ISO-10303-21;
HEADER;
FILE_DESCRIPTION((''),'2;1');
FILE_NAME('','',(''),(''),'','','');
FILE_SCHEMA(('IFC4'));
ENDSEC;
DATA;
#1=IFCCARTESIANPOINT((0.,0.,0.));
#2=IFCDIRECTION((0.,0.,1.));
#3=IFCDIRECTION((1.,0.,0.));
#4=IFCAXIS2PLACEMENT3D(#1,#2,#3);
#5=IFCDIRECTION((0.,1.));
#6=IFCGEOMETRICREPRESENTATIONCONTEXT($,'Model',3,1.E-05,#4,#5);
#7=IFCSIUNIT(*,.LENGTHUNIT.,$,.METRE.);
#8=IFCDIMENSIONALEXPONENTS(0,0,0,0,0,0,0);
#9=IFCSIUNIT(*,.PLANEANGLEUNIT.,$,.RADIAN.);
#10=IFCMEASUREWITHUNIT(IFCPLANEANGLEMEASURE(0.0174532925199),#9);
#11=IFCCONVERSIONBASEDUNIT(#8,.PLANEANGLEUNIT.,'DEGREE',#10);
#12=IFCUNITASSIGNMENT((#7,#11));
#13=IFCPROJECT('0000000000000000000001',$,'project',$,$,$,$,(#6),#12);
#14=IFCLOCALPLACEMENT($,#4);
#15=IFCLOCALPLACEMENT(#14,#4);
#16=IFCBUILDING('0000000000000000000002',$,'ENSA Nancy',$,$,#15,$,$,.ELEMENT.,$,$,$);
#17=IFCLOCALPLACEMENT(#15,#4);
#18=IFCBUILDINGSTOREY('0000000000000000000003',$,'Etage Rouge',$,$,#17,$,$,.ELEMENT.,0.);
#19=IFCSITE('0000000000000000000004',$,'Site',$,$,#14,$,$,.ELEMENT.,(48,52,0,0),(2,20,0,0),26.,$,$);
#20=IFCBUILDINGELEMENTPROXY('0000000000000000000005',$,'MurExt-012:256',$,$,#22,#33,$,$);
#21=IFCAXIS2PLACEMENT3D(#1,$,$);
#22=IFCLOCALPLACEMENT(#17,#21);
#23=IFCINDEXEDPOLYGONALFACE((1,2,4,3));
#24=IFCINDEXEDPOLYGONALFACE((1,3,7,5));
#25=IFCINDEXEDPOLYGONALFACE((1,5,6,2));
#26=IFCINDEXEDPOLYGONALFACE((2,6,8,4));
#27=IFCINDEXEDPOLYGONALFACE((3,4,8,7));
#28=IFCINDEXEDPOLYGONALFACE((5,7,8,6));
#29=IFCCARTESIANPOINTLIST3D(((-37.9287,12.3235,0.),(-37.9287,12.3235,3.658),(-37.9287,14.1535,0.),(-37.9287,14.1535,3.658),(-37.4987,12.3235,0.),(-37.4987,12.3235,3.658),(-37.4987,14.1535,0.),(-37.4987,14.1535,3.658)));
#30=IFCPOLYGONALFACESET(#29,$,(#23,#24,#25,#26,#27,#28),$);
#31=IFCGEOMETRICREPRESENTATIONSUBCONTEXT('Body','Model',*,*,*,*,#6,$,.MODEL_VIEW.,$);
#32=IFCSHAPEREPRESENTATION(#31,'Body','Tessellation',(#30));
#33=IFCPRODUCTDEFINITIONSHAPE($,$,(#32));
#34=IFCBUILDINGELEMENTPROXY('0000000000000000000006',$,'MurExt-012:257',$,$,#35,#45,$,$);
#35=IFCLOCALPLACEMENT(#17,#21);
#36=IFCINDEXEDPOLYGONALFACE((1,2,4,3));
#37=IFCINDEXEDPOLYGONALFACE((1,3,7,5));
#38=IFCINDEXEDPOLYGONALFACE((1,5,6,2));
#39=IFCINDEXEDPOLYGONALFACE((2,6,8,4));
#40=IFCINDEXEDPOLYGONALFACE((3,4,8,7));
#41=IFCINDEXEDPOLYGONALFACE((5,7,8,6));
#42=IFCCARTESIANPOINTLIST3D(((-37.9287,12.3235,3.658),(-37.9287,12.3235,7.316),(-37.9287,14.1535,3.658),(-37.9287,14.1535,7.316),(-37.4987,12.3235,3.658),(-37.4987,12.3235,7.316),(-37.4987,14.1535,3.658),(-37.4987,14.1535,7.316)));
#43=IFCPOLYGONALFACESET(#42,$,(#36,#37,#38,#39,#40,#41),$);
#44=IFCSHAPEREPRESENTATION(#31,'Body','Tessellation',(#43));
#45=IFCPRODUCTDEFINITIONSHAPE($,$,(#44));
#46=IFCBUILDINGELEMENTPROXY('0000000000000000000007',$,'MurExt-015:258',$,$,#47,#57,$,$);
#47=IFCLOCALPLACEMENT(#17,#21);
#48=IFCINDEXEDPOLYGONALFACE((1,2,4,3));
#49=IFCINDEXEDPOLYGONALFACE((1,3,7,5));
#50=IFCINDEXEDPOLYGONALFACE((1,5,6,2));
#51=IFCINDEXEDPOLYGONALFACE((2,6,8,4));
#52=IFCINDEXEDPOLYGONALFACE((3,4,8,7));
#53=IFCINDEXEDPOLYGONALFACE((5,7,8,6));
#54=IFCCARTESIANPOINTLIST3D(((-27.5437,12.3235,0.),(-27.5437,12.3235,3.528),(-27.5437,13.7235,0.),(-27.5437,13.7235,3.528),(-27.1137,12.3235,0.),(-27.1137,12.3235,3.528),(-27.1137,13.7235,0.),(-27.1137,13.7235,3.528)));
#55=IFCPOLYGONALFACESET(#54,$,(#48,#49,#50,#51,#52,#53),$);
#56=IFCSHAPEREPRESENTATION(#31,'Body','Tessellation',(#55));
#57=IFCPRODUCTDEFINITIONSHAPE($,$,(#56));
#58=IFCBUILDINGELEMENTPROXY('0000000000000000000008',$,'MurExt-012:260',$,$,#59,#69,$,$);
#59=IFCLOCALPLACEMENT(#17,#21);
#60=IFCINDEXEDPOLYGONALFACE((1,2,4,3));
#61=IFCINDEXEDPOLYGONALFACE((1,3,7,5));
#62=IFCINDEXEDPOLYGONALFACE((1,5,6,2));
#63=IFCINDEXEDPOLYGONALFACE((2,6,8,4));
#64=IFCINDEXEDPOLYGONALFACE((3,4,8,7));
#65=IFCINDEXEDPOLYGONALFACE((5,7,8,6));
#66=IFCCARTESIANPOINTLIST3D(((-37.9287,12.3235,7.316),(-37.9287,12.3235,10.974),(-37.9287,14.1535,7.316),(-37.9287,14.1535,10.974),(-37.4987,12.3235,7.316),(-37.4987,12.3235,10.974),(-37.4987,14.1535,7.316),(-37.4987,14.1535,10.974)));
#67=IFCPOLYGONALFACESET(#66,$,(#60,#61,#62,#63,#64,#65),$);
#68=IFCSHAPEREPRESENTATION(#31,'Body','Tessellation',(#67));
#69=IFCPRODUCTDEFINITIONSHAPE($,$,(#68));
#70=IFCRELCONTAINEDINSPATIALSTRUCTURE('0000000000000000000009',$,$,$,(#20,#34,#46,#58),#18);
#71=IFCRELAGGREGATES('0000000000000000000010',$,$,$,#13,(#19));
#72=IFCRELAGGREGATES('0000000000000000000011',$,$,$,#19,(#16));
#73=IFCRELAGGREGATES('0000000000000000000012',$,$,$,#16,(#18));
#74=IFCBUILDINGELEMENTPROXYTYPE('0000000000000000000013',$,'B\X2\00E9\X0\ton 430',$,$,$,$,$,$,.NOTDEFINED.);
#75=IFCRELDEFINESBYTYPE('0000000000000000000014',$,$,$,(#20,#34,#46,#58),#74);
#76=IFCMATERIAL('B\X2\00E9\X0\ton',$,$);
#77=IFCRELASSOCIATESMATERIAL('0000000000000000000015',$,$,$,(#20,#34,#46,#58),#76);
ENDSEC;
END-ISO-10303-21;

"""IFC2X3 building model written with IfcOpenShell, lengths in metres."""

from ifc_helpers import new_model, entity, si_unit, converted_unit, direction, frame, origin_with_axes, place, context, subcontext, project, spatial, polyline, outline, extrude, material, type_object, element, save


model = new_model("IFC2X3")

# Units and contexts
model_context = context("Model", 3, precision=1e-05, world=origin_with_axes(), true_north=direction((0.0, 1.0)))
body_context = subcontext(model_context, "Body", "Model", "MODEL_VIEW")
ifc_project = project(units=[si_unit("LENGTHUNIT", "METRE"), converted_unit("PLANEANGLEUNIT", "DEGREE", entity("IfcPlaneAngleMeasure", 0.0174532925199), si_unit("PLANEANGLEUNIT", "RADIAN"), dimensions=[0, 0, 0, 0, 0, 0, 0])], contexts=[model_context])

# Site, building, storey
site_placement = place(None, origin_with_axes())
site = spatial("IfcSite", under=ifc_project, at=site_placement, Name="Site", CompositionType="ELEMENT", RefLatitude=(48, 52, 0, 0), RefLongitude=(2, 20, 0, 0), RefElevation=26.0)
building_placement = place(site_placement, origin_with_axes())
building = spatial("IfcBuilding", under=site, at=building_placement, Name="ENSA Nancy", CompositionType="ELEMENT")
storey_placement = place(building_placement, origin_with_axes())
storey = spatial("IfcBuildingStorey", under=building, at=storey_placement, Name="Etage Rouge", CompositionType="ELEMENT", Elevation=0.0)

# Shared definitions
ifc_material_1 = material(Name="Béton")

# Building element proxies
building_element_proxy_type_1 = type_object("IfcBuildingElementProxyType", Name="Béton 430", PredefinedType="NOTDEFINED")
for number, where, z_axis, x_axis, name in (
    (1, (-37.9287, 14.1535, 0.0), (0.0, 0.0, 1.0), (0.0, -1.0, 0.0), "MurExt-012:256"),
    (2, (-37.9287, 14.1535, 3.658), (0.0, 0.0, 1.0), (0.0, -1.0, 0.0), "MurExt-012:257"),
):
    element("IfcBuildingElementProxy", number, at=place(storey_placement, frame(where, z_axis=z_axis, x_axis=x_axis)), inside=storey, type_object=building_element_proxy_type_1, material=ifc_material_1, Name=name, context=body_context, shape_type="SweptSolid", body=[
        extrude(outline(polyline([(0.0, 0.0), (1.83, 0.0), (1.83, 0.43), (0.0, 0.43), (0.0, 0.0)])), origin_with_axes(), (0.0, 0.0, 1.0), 3.658),
    ])
proxy_1_placement = place(storey_placement, frame((-27.5437, 13.7235, 0.0), z_axis=(0.0, 0.0, 1.0), x_axis=(0.0, -1.0, 0.0)))
element("IfcBuildingElementProxy", 3, at=proxy_1_placement, inside=storey, type_object=building_element_proxy_type_1, material=ifc_material_1, Name="MurExt-015:258", context=body_context, shape_type="SweptSolid", body=[
    extrude(outline(polyline([(0.0, 0.0), (1.4, 0.0), (1.4, 0.43), (0.0, 0.43), (0.0, 0.0)])), origin_with_axes(), (0.0, 0.0, 1.0), 3.528),
])
proxy_2_placement = place(storey_placement, frame((-37.9287, 14.1535, 7.316), z_axis=(0.0, 0.0, 1.0), x_axis=(0.0, -1.0, 0.0)))
element("IfcBuildingElementProxy", 4, at=proxy_2_placement, inside=storey, type_object=building_element_proxy_type_1, material=ifc_material_1, Name="MurExt-012:260", context=body_context, shape_type="SweptSolid", body=[
    extrude(outline(polyline([(0.0, 0.0), (1.83, 0.0), (1.83, 0.43), (0.0, 0.43), (0.0, 0.0)])), origin_with_axes(), (0.0, 0.0, 1.0), 3.658),
])

save(model, "model.ifc")
